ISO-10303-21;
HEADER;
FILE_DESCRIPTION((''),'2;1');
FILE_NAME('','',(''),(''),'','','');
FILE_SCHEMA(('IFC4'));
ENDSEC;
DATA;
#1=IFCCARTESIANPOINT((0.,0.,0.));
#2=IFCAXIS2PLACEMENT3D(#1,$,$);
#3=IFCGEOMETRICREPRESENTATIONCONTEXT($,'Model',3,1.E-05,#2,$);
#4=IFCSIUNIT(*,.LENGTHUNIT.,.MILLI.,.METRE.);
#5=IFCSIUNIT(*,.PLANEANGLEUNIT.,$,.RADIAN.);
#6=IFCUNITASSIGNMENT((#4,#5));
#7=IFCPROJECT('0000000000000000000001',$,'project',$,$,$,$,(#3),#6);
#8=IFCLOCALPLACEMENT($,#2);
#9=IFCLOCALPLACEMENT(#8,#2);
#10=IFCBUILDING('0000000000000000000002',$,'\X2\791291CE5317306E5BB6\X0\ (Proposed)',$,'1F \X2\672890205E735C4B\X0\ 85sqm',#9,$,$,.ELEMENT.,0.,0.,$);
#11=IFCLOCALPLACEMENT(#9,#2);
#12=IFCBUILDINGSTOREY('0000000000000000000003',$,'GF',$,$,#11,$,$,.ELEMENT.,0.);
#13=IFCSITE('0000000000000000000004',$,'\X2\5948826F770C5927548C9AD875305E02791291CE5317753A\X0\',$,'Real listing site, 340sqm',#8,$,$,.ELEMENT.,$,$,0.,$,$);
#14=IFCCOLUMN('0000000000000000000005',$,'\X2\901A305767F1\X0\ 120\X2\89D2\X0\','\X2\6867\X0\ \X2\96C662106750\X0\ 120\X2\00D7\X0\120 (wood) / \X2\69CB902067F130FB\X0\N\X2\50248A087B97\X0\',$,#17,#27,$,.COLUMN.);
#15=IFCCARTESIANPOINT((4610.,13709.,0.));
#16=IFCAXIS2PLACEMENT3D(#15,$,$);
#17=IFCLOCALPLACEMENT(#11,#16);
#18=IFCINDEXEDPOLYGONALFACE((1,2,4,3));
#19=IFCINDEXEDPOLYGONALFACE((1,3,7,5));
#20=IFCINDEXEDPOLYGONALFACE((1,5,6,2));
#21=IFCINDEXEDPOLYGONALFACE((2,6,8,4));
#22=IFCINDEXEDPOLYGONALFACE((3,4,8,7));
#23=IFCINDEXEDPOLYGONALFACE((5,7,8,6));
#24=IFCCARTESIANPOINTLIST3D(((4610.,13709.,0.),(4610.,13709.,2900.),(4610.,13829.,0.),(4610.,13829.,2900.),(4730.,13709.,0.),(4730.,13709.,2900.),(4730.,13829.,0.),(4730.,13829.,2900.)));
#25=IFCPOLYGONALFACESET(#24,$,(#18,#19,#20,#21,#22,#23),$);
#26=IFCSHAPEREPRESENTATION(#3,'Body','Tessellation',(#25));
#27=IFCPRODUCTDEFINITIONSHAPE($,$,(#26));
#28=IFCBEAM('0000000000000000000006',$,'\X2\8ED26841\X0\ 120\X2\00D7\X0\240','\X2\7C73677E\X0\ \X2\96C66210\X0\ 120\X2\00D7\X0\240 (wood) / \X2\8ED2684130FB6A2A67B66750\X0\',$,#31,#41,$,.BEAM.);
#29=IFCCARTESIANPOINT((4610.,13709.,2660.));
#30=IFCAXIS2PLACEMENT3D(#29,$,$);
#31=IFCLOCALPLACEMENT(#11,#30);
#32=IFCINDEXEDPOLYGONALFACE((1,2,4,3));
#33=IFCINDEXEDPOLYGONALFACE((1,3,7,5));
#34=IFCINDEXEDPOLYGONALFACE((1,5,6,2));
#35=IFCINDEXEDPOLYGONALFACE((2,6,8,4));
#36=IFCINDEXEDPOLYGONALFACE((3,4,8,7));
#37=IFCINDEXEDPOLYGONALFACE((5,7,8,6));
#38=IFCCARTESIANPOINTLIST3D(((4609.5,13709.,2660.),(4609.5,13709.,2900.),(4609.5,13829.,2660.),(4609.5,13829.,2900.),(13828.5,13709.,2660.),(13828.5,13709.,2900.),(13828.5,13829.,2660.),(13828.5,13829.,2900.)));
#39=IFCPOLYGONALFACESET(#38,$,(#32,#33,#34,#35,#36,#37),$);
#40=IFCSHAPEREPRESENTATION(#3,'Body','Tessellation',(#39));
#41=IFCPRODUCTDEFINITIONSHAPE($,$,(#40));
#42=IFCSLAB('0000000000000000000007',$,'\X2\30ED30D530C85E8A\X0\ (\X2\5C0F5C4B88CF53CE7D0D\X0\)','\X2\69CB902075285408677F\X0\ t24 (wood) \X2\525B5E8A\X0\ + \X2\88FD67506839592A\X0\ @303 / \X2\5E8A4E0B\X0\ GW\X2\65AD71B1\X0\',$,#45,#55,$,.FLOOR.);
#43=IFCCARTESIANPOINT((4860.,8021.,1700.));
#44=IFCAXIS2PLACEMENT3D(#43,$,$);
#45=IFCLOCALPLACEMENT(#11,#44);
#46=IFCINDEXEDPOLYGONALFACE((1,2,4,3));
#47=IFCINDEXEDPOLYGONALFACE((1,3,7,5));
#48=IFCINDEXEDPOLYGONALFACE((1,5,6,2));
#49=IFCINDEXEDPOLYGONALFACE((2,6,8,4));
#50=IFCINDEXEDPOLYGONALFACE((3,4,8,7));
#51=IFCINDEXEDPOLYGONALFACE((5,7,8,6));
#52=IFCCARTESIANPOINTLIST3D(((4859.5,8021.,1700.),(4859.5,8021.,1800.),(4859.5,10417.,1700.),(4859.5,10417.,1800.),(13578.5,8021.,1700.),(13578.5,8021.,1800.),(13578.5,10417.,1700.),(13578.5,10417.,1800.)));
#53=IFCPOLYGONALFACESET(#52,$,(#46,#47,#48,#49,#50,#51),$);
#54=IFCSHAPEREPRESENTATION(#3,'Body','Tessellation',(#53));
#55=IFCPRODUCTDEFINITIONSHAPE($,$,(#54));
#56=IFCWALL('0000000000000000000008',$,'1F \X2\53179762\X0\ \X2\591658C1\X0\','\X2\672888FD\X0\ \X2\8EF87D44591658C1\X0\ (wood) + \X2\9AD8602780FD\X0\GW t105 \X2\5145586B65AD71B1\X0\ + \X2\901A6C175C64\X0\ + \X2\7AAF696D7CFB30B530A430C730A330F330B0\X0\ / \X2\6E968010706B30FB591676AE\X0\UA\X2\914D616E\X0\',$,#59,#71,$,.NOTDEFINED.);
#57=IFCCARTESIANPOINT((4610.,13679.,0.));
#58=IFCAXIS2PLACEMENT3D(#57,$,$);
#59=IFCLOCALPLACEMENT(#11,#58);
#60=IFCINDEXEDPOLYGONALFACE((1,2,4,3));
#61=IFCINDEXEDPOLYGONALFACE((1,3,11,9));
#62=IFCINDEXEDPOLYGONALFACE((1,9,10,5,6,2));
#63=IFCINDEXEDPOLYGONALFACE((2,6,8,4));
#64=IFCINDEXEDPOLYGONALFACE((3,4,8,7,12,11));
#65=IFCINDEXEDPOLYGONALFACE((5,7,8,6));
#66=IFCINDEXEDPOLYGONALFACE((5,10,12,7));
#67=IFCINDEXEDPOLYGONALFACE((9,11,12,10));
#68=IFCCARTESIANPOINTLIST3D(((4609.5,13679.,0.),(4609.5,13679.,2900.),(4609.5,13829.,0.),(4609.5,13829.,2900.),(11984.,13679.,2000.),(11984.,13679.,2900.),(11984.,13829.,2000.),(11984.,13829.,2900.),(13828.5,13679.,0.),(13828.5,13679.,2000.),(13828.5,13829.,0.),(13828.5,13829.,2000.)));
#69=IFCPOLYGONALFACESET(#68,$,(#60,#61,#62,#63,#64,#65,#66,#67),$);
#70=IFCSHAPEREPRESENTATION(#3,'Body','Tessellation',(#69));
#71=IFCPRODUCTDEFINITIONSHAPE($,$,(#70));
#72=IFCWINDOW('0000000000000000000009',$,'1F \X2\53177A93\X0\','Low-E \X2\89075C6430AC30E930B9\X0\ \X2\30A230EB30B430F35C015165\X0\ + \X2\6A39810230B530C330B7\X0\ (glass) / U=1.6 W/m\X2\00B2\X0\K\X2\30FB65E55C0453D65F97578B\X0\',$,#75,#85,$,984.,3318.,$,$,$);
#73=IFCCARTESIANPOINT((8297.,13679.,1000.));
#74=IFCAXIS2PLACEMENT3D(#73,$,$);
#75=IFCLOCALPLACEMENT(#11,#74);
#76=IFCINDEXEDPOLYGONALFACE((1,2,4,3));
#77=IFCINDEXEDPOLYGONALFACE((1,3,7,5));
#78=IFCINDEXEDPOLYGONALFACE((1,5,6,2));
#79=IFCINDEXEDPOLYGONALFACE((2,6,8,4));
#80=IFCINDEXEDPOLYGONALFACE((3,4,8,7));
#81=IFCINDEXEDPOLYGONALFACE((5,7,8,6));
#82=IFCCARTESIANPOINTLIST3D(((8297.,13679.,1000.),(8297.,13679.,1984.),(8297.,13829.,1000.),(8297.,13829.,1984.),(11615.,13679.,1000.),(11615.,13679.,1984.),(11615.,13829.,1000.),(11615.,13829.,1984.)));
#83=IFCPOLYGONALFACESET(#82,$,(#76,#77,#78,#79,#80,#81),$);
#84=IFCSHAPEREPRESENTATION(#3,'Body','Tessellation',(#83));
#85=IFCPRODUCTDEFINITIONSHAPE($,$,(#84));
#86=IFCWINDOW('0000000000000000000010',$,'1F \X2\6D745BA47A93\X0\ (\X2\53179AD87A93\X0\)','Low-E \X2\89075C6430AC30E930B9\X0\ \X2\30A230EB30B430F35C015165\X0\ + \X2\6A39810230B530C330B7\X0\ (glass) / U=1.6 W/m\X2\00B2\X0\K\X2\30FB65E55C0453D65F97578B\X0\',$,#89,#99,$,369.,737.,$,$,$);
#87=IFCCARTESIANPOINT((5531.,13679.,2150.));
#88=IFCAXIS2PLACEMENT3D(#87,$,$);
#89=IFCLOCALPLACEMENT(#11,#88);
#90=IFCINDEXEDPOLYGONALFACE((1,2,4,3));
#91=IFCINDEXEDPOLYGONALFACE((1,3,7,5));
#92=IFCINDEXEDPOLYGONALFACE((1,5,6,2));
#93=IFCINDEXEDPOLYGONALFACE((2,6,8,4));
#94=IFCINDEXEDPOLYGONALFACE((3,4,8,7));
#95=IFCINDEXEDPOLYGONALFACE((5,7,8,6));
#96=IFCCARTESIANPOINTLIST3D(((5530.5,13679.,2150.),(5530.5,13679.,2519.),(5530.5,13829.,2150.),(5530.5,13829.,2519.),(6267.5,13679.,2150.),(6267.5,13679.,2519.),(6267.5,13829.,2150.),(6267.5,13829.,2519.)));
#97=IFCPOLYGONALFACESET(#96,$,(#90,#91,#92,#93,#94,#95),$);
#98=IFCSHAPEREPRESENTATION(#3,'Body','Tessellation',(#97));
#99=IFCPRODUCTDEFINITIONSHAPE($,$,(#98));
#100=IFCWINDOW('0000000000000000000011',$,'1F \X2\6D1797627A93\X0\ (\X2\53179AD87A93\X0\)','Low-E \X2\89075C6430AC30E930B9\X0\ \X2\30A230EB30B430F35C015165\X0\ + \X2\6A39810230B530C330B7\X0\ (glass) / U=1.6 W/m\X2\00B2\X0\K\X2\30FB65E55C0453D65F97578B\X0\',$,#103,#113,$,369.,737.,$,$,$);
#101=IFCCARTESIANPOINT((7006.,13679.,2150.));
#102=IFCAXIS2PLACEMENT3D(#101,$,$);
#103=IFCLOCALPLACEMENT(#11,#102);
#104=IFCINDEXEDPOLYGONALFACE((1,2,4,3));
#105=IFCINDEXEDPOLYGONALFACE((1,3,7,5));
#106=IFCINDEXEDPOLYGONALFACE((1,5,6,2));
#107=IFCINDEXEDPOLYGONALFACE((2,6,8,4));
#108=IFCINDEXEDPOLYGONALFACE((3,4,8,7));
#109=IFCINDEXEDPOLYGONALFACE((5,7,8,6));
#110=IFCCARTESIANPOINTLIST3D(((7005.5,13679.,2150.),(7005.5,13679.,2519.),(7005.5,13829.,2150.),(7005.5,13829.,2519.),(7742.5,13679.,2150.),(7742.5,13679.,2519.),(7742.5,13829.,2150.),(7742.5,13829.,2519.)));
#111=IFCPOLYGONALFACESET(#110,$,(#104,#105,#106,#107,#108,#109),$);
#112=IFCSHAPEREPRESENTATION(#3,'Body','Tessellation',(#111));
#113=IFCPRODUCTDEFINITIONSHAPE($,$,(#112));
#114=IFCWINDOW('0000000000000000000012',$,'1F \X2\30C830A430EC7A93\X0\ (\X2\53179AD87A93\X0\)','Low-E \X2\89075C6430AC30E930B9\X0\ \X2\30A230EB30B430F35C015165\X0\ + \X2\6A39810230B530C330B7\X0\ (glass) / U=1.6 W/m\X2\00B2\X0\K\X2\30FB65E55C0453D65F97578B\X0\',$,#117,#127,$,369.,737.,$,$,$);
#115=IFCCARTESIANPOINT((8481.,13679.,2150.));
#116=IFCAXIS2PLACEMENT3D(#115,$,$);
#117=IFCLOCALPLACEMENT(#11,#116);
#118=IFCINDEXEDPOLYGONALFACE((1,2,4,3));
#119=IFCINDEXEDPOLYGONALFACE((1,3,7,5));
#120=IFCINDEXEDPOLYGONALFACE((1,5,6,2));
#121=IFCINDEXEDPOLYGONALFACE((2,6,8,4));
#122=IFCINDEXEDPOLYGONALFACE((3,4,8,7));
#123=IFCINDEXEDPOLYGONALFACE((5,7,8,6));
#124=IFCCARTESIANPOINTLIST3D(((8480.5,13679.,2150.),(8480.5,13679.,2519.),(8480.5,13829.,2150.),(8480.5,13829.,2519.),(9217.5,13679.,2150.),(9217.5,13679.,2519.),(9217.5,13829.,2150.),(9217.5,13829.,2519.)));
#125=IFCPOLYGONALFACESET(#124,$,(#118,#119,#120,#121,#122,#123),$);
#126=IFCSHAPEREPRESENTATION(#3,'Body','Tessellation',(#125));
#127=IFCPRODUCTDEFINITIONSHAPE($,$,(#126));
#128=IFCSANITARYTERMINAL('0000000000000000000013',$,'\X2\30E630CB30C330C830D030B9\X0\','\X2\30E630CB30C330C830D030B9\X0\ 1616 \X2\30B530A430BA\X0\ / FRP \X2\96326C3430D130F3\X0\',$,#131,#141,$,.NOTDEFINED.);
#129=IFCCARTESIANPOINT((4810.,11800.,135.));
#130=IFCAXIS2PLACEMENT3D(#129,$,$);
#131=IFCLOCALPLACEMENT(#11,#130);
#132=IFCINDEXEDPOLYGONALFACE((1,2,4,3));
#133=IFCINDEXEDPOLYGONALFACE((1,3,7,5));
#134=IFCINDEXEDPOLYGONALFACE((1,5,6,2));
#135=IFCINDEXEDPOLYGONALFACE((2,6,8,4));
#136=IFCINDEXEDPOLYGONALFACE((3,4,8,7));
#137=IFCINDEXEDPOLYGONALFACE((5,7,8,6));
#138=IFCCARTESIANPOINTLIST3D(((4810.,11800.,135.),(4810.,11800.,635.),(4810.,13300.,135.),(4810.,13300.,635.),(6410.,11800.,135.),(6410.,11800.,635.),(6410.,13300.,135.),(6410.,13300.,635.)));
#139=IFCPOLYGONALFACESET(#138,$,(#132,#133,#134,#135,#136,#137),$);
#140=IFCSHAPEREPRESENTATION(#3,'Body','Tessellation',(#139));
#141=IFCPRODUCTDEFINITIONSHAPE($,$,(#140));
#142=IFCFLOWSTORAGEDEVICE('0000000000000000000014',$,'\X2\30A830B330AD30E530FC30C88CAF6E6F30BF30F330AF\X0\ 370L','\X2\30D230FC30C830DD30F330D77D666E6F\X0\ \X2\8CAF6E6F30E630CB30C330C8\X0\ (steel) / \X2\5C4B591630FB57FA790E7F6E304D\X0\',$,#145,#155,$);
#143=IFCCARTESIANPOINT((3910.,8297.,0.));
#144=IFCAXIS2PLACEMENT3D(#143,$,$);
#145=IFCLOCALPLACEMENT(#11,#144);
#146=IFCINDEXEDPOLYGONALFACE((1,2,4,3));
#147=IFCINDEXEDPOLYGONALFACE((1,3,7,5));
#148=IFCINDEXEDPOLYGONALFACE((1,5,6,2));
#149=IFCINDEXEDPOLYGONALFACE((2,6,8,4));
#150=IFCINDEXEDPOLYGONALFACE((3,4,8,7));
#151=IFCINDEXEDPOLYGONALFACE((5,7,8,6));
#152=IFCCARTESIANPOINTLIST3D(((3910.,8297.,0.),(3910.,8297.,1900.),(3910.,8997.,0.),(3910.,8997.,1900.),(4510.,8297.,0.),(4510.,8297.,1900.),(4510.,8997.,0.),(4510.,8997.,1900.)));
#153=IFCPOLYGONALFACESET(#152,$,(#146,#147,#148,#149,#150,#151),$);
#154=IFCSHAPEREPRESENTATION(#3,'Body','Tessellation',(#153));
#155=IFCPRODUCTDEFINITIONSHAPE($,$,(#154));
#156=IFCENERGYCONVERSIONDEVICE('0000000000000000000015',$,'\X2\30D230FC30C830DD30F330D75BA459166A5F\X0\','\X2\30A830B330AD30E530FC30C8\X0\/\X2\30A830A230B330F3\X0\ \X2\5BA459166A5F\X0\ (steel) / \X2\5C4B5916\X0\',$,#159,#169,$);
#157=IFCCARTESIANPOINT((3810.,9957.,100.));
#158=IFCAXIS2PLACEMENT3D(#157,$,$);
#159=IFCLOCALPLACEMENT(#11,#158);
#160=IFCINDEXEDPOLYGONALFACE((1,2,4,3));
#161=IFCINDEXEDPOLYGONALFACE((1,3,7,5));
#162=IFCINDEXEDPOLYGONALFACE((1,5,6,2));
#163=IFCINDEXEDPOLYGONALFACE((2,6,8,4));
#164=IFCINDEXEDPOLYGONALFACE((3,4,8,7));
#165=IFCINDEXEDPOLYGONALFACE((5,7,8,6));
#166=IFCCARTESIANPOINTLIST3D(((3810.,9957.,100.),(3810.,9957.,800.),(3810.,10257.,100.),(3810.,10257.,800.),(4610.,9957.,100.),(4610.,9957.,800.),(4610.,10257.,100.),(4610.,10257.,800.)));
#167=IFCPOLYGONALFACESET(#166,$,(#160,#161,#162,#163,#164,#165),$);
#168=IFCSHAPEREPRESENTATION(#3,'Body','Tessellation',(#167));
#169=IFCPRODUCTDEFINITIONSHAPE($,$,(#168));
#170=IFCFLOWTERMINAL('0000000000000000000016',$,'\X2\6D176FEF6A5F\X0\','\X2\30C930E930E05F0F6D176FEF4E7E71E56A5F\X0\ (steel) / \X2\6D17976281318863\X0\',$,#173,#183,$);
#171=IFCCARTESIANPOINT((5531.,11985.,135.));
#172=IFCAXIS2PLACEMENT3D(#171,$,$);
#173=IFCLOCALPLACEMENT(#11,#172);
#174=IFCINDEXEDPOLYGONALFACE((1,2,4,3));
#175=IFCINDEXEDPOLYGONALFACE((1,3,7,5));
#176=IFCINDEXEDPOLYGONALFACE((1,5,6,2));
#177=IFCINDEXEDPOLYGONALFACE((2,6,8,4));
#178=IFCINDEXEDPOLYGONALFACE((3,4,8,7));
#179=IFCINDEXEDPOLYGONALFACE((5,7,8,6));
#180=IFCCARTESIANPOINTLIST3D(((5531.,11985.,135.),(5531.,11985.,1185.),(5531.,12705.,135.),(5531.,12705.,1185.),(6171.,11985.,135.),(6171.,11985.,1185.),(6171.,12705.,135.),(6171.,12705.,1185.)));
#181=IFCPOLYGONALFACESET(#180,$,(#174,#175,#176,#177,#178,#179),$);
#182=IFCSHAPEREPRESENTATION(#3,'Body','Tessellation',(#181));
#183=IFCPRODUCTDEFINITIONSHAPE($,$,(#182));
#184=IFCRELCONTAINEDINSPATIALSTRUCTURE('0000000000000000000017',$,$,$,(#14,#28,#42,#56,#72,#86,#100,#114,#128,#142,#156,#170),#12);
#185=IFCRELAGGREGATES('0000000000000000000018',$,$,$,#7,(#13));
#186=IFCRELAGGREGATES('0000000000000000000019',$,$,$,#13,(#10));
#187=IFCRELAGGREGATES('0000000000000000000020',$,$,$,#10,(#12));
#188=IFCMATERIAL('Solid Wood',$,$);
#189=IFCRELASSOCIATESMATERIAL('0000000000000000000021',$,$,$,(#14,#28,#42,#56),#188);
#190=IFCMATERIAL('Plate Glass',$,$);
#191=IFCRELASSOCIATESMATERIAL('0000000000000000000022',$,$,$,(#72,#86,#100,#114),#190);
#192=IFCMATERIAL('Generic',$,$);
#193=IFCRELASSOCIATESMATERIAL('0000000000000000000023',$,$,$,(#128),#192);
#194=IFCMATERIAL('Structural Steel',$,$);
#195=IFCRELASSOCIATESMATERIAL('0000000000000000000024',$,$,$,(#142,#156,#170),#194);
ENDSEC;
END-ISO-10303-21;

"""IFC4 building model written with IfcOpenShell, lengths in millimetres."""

from ifc_helpers import new_model, si_unit, frame, frame_2d, origin, place, context, project, spatial, rectangle, extrude, material, element, fill, save


model = new_model("IFC4")

# Units and contexts
model_context = context("Model", 3, precision=1e-05, world=origin())
ifc_project = project(units=[si_unit("LENGTHUNIT", "METRE", prefix="MILLI"), si_unit("PLANEANGLEUNIT", "RADIAN")], contexts=[model_context])

# Site, building, storey
site_placement = place(None, origin())
site = spatial("IfcSite", under=ifc_project, at=site_placement, Name="奈良県大和高田市礒野北町", ObjectType="Real listing site, 340sqm", CompositionType="ELEMENT", RefElevation=0.0)
building_placement = place(site_placement, origin())
building = spatial("IfcBuilding", under=site, at=building_placement, Name="礒野北の家 (Proposed)", ObjectType="1F 木造平屋 85sqm", CompositionType="ELEMENT", ElevationOfRefHeight=0.0, ElevationOfTerrain=0.0)
storey_placement = place(building_placement, origin())
storey = spatial("IfcBuildingStorey", under=building, at=storey_placement, Name="GF", CompositionType="ELEMENT", Elevation=0.0)

# Column
ifc_material_1 = material(Name="Solid Wood")
column_1_placement = place(storey_placement, frame((4610.0, 13709.0, 0.0)))
element("IfcColumn", 1, at=column_1_placement, inside=storey, material=ifc_material_1, Name="通し柱 120角", Description="桧 集成材 120×120 (wood) / 構造柱・N値計算", PredefinedType="COLUMN", context=model_context, shape_type="SweptSolid", body=[
    extrude(rectangle(XDim=120.0, YDim=120.0, at=frame_2d((60.0, 60.0))), frame((4610.0, 13709.0, 0.0)), (0.0, 0.0, 1.0), 2900.0),
])

# Beam
beam_1_placement = place(storey_placement, frame((4610.0, 13709.0, 2660.0)))
element("IfcBeam", 2, at=beam_1_placement, inside=storey, material=ifc_material_1, Name="軒桁 120×240", Description="米松 集成 120×240 (wood) / 軒桁・横架材", PredefinedType="BEAM", context=model_context, shape_type="SweptSolid", body=[
    extrude(rectangle(XDim=9219.0, YDim=120.0, at=frame_2d((4609.0, 60.0))), frame((4610.0, 13709.0, 2660.0)), (0.0, 0.0, 1.0), 240.0),
])

# Slab
slab_placement = place(storey_placement, frame((4860.0, 8021.0, 1700.0)))
element("IfcSlab", 3, at=slab_placement, inside=storey, material=ifc_material_1, Name="ロフト床 (小屋裏収納)", Description="構造用合板 t24 (wood) 剛床 + 製材根太 @303 / 床下 GW断熱", PredefinedType="FLOOR", context=model_context, shape_type="SweptSolid", body=[
    extrude(rectangle(XDim=8719.0, YDim=2396.0, at=frame_2d((4359.0, 1198.0))), frame((4860.0, 8021.0, 1700.0)), (0.0, 0.0, 1.0), 100.0),
])

# Wall, openings, windows
wall_1_placement = place(storey_placement, frame((4610.0, 13679.0, 0.0)))
wall_1 = element("IfcWall", 4, at=wall_1_placement, inside=storey, material=ifc_material_1, Name="1F 北面 外壁", Description="木製 軸組外壁 (wood) + 高性能GW t105 充填断熱 + 通気層 + 窯業系サイディング / 準耐火・外皮UA配慮", PredefinedType="NOTDEFINED", context=model_context, shape_type="SweptSolid", body=[
    extrude(rectangle(XDim=9219.0, YDim=150.0, at=frame_2d((4609.0, 75.0))), frame((4610.0, 13679.0, 0.0)), (0.0, 0.0, 1.0), 2900.0),
])
opening_1_placement = place(storey_placement, frame((8297.0, 13679.0, 1000.0)))
opening_1 = element("IfcOpeningElement", 5, at=opening_1_placement, cuts=wall_1, PredefinedType="NOTDEFINED", context=model_context, shape_type="SweptSolid", body=[
    extrude(rectangle(XDim=3318.0, YDim=150.0, at=frame_2d((1659.0, 75.0))), frame((8297.0, 13679.0, 1000.0)), (0.0, 0.0, 1.0), 984.0),
])
opening_2_placement = place(storey_placement, frame((5531.0, 13679.0, 2150.0)))
opening_2 = element("IfcOpeningElement", 6, at=opening_2_placement, cuts=wall_1, PredefinedType="NOTDEFINED", context=model_context, shape_type="SweptSolid", body=[
    extrude(rectangle(XDim=737.0, YDim=150.0, at=frame_2d((368.0, 75.0))), frame((5531.0, 13679.0, 2150.0)), (0.0, 0.0, 1.0), 369.0),
])
opening_3_placement = place(storey_placement, frame((7006.0, 13679.0, 2150.0)))
opening_3 = element("IfcOpeningElement", 7, at=opening_3_placement, cuts=wall_1, PredefinedType="NOTDEFINED", context=model_context, shape_type="SweptSolid", body=[
    extrude(rectangle(XDim=737.0, YDim=150.0, at=frame_2d((368.0, 75.0))), frame((7006.0, 13679.0, 2150.0)), (0.0, 0.0, 1.0), 369.0),
])
opening_4_placement = place(storey_placement, frame((8481.0, 13679.0, 2150.0)))
opening_4 = element("IfcOpeningElement", 8, at=opening_4_placement, cuts=wall_1, PredefinedType="NOTDEFINED", context=model_context, shape_type="SweptSolid", body=[
    extrude(rectangle(XDim=737.0, YDim=150.0, at=frame_2d((368.0, 75.0))), frame((8481.0, 13679.0, 2150.0)), (0.0, 0.0, 1.0), 369.0),
])
ifc_material_2 = material(Name="Plate Glass")
window_1_placement = place(storey_placement, frame((8297.0, 13679.0, 1000.0)))
window_1 = element("IfcWindow", 9, at=window_1_placement, inside=storey, material=ifc_material_2, Name="1F 北窓", Description="Low-E 複層ガラス アルゴン封入 + 樹脂サッシ (glass) / U=1.6 W/m²K・日射取得型", OverallHeight=984.0, OverallWidth=3318.0, context=model_context, shape_type="SweptSolid", body=[
    extrude(rectangle(XDim=3318.0, YDim=150.0, at=frame_2d((1659.0, 75.0))), frame((8297.0, 13679.0, 1000.0)), (0.0, 0.0, 1.0), 984.0),
])
fill(opening_1, window_1)
window_2_placement = place(storey_placement, frame((5531.0, 13679.0, 2150.0)))
window_2 = element("IfcWindow", 10, at=window_2_placement, inside=storey, material=ifc_material_2, Name="1F 浴室窓 (北高窓)", Description="Low-E 複層ガラス アルゴン封入 + 樹脂サッシ (glass) / U=1.6 W/m²K・日射取得型", OverallHeight=369.0, OverallWidth=737.0, context=model_context, shape_type="SweptSolid", body=[
    extrude(rectangle(XDim=737.0, YDim=150.0, at=frame_2d((368.0, 75.0))), frame((5531.0, 13679.0, 2150.0)), (0.0, 0.0, 1.0), 369.0),
])
fill(opening_2, window_2)
window_3_placement = place(storey_placement, frame((7006.0, 13679.0, 2150.0)))
window_3 = element("IfcWindow", 11, at=window_3_placement, inside=storey, material=ifc_material_2, Name="1F 洗面窓 (北高窓)", Description="Low-E 複層ガラス アルゴン封入 + 樹脂サッシ (glass) / U=1.6 W/m²K・日射取得型", OverallHeight=369.0, OverallWidth=737.0, context=model_context, shape_type="SweptSolid", body=[
    extrude(rectangle(XDim=737.0, YDim=150.0, at=frame_2d((368.0, 75.0))), frame((7006.0, 13679.0, 2150.0)), (0.0, 0.0, 1.0), 369.0),
])
fill(opening_3, window_3)
window_4_placement = place(storey_placement, frame((8481.0, 13679.0, 2150.0)))
window_4 = element("IfcWindow", 12, at=window_4_placement, inside=storey, material=ifc_material_2, Name="1F トイレ窓 (北高窓)", Description="Low-E 複層ガラス アルゴン封入 + 樹脂サッシ (glass) / U=1.6 W/m²K・日射取得型", OverallHeight=369.0, OverallWidth=737.0, context=model_context, shape_type="SweptSolid", body=[
    extrude(rectangle(XDim=737.0, YDim=150.0, at=frame_2d((368.0, 75.0))), frame((8481.0, 13679.0, 2150.0)), (0.0, 0.0, 1.0), 369.0),
])
fill(opening_4, window_4)

# Sanitary terminal
ifc_material_3 = material(Name="Generic")
sanitary_terminal_placement = place(storey_placement, frame((4810.0, 11800.0, 135.0)))
element("IfcSanitaryTerminal", 13, at=sanitary_terminal_placement, inside=storey, material=ifc_material_3, Name="ユニットバス", Description="ユニットバス 1616 サイズ / FRP 防水パン", PredefinedType="NOTDEFINED", context=model_context, shape_type="SweptSolid", body=[
    extrude(rectangle(XDim=1600.0, YDim=1500.0, at=frame_2d((800.0, 750.0))), frame((4810.0, 11800.0, 135.0)), (0.0, 0.0, 1.0), 500.0),
])

# Flow storage device
ifc_material_4 = material(Name="Structural Steel")
flow_storage_device_placement = place(storey_placement, frame((3910.0, 8297.0, 0.0)))
element("IfcFlowStorageDevice", 14, at=flow_storage_device_placement, inside=storey, material=ifc_material_4, Name="エコキュート貯湯タンク 370L", Description="ヒートポンプ給湯 貯湯ユニット (steel) / 屋外・基礎置き", context=model_context, shape_type="SweptSolid", body=[
    extrude(rectangle(XDim=600.0, YDim=700.0, at=frame_2d((300.0, 350.0))), frame((3910.0, 8297.0, 0.0)), (0.0, 0.0, 1.0), 1900.0),
])

# Energy conversion device
energy_conversion_device_placement = place(storey_placement, frame((3810.0, 9957.0, 100.0)))
element("IfcEnergyConversionDevice", 15, at=energy_conversion_device_placement, inside=storey, material=ifc_material_4, Name="ヒートポンプ室外機", Description="エコキュート/エアコン 室外機 (steel) / 屋外", context=model_context, shape_type="SweptSolid", body=[
    extrude(rectangle(XDim=800.0, YDim=300.0, at=frame_2d((400.0, 150.0))), frame((3810.0, 9957.0, 100.0)), (0.0, 0.0, 1.0), 700.0),
])

# Flow terminal
flow_terminal_placement = place(storey_placement, frame((5531.0, 11985.0, 135.0)))
element("IfcFlowTerminal", 16, at=flow_terminal_placement, inside=storey, material=ifc_material_4, Name="洗濯機", Description="ドラム式洗濯乾燥機 (steel) / 洗面脱衣", context=model_context, shape_type="SweptSolid", body=[
    extrude(rectangle(XDim=640.0, YDim=720.0, at=frame_2d((320.0, 360.0))), frame((5531.0, 11985.0, 135.0)), (0.0, 0.0, 1.0), 1050.0),
])

save(model, "model.ifc")
